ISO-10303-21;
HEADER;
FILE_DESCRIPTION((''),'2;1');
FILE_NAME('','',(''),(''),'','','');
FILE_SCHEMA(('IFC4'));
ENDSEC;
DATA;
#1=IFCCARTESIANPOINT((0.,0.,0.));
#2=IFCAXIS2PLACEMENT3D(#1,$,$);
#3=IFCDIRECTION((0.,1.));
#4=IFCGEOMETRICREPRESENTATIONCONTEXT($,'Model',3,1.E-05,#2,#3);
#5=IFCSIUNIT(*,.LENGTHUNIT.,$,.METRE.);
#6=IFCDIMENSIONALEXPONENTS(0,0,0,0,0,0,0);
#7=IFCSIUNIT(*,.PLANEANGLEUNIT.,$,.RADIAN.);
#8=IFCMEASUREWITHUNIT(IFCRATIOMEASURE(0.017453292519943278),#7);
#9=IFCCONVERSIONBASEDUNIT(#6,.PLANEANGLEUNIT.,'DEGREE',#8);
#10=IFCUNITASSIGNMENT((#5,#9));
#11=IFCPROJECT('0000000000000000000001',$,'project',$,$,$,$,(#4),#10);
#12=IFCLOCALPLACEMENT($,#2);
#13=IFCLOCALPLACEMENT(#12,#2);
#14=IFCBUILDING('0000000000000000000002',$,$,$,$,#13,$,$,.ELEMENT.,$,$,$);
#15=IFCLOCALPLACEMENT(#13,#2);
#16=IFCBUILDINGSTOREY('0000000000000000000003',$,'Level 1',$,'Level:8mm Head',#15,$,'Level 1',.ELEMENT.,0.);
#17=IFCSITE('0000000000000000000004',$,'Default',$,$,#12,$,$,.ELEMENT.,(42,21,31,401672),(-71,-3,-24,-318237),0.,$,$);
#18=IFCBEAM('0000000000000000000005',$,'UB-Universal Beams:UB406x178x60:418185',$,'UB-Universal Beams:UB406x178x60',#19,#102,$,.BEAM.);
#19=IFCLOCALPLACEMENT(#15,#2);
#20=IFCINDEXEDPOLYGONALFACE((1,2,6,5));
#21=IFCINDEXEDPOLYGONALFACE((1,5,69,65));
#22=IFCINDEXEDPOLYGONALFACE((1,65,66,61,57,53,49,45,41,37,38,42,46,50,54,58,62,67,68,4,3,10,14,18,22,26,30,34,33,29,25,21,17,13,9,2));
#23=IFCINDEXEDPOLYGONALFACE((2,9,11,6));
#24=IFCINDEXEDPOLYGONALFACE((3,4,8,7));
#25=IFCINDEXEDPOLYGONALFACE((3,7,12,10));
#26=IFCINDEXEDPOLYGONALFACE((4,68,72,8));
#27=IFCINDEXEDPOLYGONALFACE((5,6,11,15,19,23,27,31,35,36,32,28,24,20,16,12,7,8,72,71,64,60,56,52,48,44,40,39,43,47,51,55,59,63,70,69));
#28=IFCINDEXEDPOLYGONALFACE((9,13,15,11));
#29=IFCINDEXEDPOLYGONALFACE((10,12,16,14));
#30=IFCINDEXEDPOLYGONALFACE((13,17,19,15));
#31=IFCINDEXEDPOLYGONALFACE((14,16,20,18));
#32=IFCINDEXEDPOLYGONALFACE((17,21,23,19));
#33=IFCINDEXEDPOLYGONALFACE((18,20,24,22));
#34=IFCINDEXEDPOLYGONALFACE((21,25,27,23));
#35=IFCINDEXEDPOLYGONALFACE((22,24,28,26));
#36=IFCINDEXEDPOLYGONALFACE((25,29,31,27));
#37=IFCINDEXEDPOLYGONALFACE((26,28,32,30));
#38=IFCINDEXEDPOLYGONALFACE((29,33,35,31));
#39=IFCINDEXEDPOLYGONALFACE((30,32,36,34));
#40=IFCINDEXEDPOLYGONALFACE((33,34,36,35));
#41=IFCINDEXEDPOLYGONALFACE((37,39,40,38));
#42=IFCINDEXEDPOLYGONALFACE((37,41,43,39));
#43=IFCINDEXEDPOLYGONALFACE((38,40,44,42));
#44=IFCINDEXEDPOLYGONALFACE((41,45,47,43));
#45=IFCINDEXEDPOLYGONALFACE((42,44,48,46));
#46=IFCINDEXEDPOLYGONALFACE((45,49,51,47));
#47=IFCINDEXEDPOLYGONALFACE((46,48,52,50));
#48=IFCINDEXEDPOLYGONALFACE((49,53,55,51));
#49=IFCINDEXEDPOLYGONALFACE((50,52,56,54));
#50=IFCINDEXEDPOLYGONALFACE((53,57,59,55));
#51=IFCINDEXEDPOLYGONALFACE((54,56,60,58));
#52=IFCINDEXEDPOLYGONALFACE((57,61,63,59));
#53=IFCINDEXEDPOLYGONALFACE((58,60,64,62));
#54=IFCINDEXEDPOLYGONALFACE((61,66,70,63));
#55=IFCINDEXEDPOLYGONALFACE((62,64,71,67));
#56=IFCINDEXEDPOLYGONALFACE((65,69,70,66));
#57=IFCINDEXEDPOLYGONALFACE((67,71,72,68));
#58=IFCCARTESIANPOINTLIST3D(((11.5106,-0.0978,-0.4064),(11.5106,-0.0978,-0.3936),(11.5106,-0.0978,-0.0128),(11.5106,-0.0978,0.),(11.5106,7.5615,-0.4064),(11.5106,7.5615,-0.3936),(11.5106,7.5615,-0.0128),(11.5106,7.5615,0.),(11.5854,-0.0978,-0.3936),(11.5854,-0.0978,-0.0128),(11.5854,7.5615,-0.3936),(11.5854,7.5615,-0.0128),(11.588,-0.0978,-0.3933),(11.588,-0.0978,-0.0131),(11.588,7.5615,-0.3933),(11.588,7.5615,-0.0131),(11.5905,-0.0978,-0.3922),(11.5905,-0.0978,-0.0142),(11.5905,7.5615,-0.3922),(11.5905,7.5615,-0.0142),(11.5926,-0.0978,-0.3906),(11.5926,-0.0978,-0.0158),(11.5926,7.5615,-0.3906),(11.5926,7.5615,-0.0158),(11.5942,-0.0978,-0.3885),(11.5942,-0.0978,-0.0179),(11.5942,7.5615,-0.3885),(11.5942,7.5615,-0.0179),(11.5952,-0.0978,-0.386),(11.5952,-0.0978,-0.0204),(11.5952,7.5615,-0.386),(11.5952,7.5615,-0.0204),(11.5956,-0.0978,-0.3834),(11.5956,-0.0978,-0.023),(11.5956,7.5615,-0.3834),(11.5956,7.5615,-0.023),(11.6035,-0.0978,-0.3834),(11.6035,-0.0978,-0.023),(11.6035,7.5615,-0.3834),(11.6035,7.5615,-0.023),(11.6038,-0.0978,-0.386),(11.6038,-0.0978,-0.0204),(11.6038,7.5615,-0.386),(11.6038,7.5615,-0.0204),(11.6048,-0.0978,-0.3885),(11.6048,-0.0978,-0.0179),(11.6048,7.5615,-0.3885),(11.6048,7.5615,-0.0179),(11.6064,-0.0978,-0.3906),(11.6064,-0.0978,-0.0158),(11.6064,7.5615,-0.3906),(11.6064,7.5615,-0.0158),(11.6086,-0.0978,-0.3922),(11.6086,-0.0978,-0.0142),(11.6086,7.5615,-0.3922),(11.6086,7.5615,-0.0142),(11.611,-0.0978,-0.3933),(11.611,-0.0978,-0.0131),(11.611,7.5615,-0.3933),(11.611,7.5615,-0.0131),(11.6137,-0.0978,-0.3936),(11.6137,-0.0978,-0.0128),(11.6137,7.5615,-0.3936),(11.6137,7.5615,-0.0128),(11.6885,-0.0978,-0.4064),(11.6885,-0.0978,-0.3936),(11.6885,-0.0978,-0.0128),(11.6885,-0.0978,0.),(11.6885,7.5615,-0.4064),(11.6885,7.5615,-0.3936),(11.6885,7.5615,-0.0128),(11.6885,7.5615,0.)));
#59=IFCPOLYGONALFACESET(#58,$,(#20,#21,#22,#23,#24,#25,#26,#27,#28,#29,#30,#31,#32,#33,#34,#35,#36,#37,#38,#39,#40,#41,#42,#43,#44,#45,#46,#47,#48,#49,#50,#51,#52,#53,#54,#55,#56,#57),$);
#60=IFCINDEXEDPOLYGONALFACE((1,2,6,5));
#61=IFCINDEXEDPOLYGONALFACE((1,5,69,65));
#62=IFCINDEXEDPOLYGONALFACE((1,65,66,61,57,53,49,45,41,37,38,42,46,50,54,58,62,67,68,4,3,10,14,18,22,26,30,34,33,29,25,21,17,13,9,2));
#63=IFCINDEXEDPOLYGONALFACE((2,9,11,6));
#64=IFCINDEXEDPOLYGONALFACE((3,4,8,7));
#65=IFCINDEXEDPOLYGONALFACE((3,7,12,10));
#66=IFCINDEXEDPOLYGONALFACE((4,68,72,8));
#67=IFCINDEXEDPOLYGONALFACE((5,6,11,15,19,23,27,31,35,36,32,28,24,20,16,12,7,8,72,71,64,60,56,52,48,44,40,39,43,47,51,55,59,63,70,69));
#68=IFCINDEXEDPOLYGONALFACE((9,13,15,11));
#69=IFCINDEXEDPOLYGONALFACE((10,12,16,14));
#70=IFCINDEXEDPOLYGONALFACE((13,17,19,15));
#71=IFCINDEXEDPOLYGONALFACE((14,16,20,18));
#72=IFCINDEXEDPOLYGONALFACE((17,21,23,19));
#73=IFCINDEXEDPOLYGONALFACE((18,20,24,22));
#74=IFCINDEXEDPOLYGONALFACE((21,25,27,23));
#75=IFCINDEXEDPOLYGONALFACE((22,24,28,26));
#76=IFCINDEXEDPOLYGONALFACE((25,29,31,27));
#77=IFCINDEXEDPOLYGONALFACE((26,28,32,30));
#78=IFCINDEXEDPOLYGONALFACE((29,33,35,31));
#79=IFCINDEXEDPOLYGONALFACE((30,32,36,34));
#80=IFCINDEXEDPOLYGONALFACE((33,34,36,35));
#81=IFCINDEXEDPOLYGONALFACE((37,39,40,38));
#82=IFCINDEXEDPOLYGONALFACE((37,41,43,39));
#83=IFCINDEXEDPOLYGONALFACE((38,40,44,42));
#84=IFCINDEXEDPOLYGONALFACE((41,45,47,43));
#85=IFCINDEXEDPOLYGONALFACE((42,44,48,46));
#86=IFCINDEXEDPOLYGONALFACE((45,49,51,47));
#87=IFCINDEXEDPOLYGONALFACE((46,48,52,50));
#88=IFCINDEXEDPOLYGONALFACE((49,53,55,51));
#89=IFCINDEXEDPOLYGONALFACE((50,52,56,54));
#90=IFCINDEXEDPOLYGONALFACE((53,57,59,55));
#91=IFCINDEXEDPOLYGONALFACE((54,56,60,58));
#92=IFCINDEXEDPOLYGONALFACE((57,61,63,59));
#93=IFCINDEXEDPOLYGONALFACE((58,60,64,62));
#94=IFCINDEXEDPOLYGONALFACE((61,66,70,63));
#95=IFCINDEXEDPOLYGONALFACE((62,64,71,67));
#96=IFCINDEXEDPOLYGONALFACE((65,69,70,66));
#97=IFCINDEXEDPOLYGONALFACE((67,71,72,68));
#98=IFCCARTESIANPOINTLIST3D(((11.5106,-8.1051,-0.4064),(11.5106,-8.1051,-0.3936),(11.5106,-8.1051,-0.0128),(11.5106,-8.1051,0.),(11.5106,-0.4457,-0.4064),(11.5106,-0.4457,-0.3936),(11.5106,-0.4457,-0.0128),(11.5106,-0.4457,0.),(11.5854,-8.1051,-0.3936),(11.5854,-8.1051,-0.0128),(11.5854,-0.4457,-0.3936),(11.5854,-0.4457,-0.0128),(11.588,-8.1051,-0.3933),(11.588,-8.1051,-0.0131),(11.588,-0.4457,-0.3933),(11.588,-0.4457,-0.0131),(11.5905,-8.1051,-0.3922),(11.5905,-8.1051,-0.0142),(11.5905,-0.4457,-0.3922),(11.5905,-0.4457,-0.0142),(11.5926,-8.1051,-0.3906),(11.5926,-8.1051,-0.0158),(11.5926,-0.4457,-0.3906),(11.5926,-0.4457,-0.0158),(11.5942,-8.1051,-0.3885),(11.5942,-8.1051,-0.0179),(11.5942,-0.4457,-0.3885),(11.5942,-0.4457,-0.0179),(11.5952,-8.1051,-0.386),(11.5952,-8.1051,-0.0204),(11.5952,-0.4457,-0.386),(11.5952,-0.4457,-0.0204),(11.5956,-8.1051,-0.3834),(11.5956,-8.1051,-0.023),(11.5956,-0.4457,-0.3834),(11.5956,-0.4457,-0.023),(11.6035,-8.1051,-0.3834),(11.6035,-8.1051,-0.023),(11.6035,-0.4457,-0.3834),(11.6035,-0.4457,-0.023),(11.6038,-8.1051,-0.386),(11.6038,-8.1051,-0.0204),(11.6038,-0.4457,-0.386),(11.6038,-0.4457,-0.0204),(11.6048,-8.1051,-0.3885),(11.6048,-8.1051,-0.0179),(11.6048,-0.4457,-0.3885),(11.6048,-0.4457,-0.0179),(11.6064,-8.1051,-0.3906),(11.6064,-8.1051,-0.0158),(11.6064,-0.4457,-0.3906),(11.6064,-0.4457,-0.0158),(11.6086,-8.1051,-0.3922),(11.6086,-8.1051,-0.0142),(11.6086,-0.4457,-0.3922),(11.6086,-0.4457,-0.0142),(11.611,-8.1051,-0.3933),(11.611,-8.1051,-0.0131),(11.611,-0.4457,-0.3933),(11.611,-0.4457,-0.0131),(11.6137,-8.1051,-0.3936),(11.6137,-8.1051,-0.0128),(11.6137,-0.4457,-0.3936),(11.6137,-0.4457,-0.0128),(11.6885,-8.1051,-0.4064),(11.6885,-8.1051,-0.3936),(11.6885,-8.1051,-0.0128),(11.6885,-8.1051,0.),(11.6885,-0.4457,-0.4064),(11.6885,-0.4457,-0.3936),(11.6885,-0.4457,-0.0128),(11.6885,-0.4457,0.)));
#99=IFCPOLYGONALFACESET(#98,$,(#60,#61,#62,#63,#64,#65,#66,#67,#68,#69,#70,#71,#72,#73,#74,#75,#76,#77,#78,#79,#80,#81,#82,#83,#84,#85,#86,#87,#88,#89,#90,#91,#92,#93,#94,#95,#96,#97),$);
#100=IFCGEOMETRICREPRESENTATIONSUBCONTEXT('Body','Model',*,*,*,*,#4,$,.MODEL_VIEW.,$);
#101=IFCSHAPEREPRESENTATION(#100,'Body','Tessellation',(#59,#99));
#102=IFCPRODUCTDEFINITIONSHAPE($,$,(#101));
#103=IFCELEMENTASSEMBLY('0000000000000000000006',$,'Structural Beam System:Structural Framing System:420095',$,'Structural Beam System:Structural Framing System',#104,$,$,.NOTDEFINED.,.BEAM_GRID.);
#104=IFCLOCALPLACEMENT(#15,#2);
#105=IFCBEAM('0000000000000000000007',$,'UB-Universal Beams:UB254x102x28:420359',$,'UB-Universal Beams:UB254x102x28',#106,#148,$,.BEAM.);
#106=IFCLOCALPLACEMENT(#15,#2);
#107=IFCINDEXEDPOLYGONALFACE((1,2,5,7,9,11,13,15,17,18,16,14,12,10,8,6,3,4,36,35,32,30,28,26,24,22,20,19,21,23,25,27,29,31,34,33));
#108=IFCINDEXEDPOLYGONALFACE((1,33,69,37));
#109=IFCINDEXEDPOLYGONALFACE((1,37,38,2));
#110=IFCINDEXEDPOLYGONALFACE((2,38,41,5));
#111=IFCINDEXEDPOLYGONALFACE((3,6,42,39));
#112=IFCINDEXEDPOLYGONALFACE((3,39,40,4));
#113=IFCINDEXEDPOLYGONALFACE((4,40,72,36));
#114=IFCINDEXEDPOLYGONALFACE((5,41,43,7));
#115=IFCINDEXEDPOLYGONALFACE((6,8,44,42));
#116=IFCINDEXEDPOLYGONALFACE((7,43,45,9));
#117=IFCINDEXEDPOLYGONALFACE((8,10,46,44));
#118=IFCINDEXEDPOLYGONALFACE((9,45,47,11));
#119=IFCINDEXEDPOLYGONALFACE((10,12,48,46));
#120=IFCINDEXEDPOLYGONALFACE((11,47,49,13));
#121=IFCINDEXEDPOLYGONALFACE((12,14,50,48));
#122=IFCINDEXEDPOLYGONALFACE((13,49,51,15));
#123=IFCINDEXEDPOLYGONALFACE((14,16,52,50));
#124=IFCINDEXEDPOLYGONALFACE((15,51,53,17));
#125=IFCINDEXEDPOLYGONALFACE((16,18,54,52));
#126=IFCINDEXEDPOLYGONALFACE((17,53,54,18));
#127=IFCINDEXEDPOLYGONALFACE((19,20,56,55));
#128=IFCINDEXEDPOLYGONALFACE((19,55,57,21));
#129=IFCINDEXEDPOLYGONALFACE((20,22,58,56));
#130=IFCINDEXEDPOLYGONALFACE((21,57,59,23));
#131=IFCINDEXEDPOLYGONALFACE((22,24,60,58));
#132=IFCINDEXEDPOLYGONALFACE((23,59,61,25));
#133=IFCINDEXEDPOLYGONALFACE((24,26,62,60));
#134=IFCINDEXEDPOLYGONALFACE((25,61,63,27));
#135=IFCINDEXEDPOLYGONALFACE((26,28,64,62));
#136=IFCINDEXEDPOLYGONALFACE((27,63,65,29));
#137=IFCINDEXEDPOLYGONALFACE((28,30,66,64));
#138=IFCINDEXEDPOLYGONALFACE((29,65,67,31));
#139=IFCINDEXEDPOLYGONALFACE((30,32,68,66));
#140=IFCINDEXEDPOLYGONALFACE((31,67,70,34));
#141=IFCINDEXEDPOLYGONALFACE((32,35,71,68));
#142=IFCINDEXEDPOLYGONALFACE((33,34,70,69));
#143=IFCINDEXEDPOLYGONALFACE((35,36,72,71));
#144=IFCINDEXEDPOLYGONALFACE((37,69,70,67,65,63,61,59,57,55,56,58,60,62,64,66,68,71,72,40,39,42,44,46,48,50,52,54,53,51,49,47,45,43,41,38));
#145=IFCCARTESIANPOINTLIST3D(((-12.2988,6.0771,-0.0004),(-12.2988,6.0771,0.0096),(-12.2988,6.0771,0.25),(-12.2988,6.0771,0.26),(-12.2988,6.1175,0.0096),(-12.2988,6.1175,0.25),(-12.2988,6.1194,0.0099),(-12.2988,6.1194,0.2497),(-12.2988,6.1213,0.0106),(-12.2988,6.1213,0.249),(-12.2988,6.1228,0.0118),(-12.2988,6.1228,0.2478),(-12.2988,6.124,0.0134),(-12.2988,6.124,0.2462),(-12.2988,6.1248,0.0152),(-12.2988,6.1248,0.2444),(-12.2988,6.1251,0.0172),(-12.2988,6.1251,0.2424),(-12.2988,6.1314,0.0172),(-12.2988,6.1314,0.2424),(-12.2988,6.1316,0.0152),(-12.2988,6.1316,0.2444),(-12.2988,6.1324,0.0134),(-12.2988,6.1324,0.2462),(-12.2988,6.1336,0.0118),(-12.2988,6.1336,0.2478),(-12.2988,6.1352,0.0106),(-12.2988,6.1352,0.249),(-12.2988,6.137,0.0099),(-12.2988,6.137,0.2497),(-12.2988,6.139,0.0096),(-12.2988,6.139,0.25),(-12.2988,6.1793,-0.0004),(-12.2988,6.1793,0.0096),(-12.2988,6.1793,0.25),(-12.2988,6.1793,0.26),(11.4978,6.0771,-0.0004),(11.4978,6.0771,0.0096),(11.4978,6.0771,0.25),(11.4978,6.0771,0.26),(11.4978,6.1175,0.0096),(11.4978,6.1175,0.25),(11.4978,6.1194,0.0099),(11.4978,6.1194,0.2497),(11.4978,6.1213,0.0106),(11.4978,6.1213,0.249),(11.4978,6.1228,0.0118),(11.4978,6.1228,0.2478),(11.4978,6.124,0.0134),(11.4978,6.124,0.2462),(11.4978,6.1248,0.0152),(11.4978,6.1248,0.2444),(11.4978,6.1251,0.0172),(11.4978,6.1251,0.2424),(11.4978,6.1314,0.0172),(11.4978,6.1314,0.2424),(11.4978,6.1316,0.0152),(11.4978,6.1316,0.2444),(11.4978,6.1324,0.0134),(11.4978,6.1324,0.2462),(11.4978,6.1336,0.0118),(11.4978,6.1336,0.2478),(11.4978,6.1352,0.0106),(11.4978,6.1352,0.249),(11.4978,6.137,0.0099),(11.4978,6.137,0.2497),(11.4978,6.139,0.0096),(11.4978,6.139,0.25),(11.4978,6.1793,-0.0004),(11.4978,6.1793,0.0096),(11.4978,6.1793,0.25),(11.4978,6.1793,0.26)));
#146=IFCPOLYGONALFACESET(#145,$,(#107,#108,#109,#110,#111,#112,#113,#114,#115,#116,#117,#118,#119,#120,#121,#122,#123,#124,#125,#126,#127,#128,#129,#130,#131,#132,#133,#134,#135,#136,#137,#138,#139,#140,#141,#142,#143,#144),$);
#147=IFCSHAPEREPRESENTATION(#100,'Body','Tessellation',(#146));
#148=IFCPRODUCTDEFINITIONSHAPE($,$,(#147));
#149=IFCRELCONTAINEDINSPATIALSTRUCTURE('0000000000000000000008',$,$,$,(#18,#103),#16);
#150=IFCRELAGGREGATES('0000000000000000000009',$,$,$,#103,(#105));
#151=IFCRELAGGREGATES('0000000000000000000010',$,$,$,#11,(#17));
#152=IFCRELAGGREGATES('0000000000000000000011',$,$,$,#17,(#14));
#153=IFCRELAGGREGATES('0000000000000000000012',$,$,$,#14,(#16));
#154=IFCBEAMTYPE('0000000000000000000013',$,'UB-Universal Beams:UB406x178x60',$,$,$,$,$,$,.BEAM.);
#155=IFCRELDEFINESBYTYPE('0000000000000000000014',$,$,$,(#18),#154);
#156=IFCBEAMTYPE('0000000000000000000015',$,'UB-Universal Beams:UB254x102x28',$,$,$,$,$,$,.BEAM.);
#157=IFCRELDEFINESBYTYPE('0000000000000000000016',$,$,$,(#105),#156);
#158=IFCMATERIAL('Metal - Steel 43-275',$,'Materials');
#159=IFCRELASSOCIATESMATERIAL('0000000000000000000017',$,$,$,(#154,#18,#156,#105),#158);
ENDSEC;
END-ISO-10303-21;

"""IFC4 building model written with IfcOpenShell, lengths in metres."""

from ifc_helpers import new_model, entity, si_unit, converted_unit, direction, frame, origin, place, context, subcontext, project, spatial, line, arc, indexed_curve, outline, extrude, source, transform, mapped, material, type_object, type_shapes, element, aggregate, save


model = new_model("IFC4")

# Units and contexts
model_context = context("Model", 3, precision=1e-05, world=origin(), true_north=direction((0.0, 1.0)))
body_context = subcontext(model_context, "Body", "Model", "MODEL_VIEW")
ifc_project = project(units=[si_unit("LENGTHUNIT", "METRE"), converted_unit("PLANEANGLEUNIT", "DEGREE", entity("IfcRatioMeasure", 0.017453292519943278), si_unit("PLANEANGLEUNIT", "RADIAN"), dimensions=[0, 0, 0, 0, 0, 0, 0])], contexts=[model_context])

# Site, building, storey
site_placement = place(None, origin())
site = spatial("IfcSite", under=ifc_project, at=site_placement, Name="Default", CompositionType="ELEMENT", RefLatitude=(42, 21, 31, 401672), RefLongitude=(-71, -3, -24, -318237), RefElevation=0.0)
building_placement = place(site_placement, origin())
building = spatial("IfcBuilding", under=site, at=building_placement, CompositionType="ELEMENT")
storey_placement = place(building_placement, origin())
storey = spatial("IfcBuildingStorey", under=building, at=storey_placement, Name="Level 1", ObjectType="Level:8mm Head", LongName="Level 1", CompositionType="ELEMENT", Elevation=0.0)

# Beam
ifc_material_1 = material(Name="Metal - Steel 43-275", Category="Materials")
beam_type_1 = type_object("IfcBeamType", Name="UB-Universal Beams:UB406x178x60", PredefinedType="BEAM", material=ifc_material_1)
shared_shape_1 = source(origin(), body_context, "Body", "SweptSolid", [
    extrude(outline(indexed_curve([(-0.0889, -0.2032), (0.089, -0.2032), (0.089, -0.1904), (0.0142, -0.1904), (0.0069, -0.1874), (0.004, -0.1802), (0.004, 0.1802), (0.0069, 0.1874), (0.0142, 0.1904), (0.089, 0.1904), (0.089, 0.2032), (-0.0889, 0.2032), (-0.0889, 0.1904), (-0.0141, 0.1904), (-0.0069, 0.1874), (-0.0039, 0.1802), (-0.0039, -0.1802), (-0.0069, -0.1874), (-0.0141, -0.1904), (-0.0889, -0.1904)], segments=[line(1, 2, 3, 4), arc(4, 5, 6), line(6, 7), arc(7, 8, 9), line(9, 10, 11, 12, 13, 14), arc(14, 15, 16), line(16, 17), arc(17, 18, 19), line(19, 20, 1)], self_intersect=False)), frame((11.5995, -0.0978, -0.2032), z_axis=(0.0, 1.0, 0.0), x_axis=(-1.0, 0.0, 0.0)), (0.0, 0.0, 1.0), 7.6594),
    extrude(outline(indexed_curve([(-0.089, -0.2032), (0.0889, -0.2032), (0.0889, -0.1904), (0.0141, -0.1904), (0.0069, -0.1874), (0.0039, -0.1802), (0.0039, 0.1802), (0.0069, 0.1874), (0.0141, 0.1904), (0.0889, 0.1904), (0.0889, 0.2032), (-0.089, 0.2032), (-0.089, 0.1904), (-0.0142, 0.1904), (-0.0069, 0.1874), (-0.004, 0.1802), (-0.004, -0.1802), (-0.0069, -0.1874), (-0.0142, -0.1904), (-0.089, -0.1904)], segments=[line(1, 2, 3, 4), arc(4, 5, 6), line(6, 7), arc(7, 8, 9), line(9, 10, 11, 12, 13, 14), arc(14, 15, 16), line(16, 17), arc(17, 18, 19), line(19, 20, 1)], self_intersect=False)), frame((11.5995, -8.1051, -0.2032), z_axis=(0.0, 1.0, 0.0), x_axis=(-1.0, 0.0, 0.0)), (0.0, 0.0, 1.0), 7.6594),
])
type_shapes(beam_type_1, [shared_shape_1])
beam_1_placement = place(storey_placement, origin())
element("IfcBeam", 1, at=beam_1_placement, inside=storey, type_object=beam_type_1, material=ifc_material_1, Name="UB-Universal Beams:UB406x178x60:418185", ObjectType="UB-Universal Beams:UB406x178x60", PredefinedType="BEAM", context=body_context, shape_type="MappedRepresentation", body=[
    mapped(shared_shape_1, transform((0.0, 0.0, 0.0), scale=1.0)),
])

# Element assembly, beam
assembly_placement = place(storey_placement, origin())
assembly = element("IfcElementAssembly", 2, at=assembly_placement, inside=storey, Name="Structural Beam System:Structural Framing System:420095", ObjectType="Structural Beam System:Structural Framing System", AssemblyPlace="NOTDEFINED", PredefinedType="BEAM_GRID")
beam_type_2 = type_object("IfcBeamType", Name="UB-Universal Beams:UB254x102x28", PredefinedType="BEAM", material=ifc_material_1)
shared_shape_2 = source(origin(), body_context, "Body", "SweptSolid", [
    extrude(outline(indexed_curve([(-0.1302, -0.0511), (-0.1202, -0.0511), (-0.1202, -0.0107), (-0.118, -0.0054), (-0.1126, -0.0031), (0.1126, -0.0031), (0.118, -0.0054), (0.1202, -0.0107), (0.1202, -0.0511), (0.1302, -0.0511), (0.1302, 0.0511), (0.1202, 0.0511), (0.1202, 0.0108), (0.118, 0.0054), (0.1126, 0.0032), (-0.1126, 0.0032), (-0.118, 0.0054), (-0.1202, 0.0108), (-0.1202, 0.0511), (-0.1302, 0.0511)], segments=[line(1, 2, 3), arc(3, 4, 5), line(5, 6), arc(6, 7, 8), line(8, 9, 10, 11, 12, 13), arc(13, 14, 15), line(15, 16), arc(16, 17, 18), line(18, 19, 20, 1)], self_intersect=False)), frame((-11.8983, 0.0, 0.0), z_axis=(1.0, 0.0, 0.0), x_axis=(0.0, 0.0, -1.0)), (0.0, 0.0, 1.0), 23.7966),
])
type_shapes(beam_type_2, [shared_shape_2])
beam_2_placement = place(assembly_placement, frame((-0.4005, 6.1282, 0.1298)))
beam_2 = element("IfcBeam", 3, at=beam_2_placement, type_object=beam_type_2, material=ifc_material_1, Name="UB-Universal Beams:UB254x102x28:420359", ObjectType="UB-Universal Beams:UB254x102x28", PredefinedType="BEAM", context=body_context, shape_type="MappedRepresentation", body=[
    mapped(shared_shape_2, transform((0.0, 0.0, 0.0), scale=1.0)),
])
aggregate(assembly, [beam_2])

save(model, "model.ifc")
